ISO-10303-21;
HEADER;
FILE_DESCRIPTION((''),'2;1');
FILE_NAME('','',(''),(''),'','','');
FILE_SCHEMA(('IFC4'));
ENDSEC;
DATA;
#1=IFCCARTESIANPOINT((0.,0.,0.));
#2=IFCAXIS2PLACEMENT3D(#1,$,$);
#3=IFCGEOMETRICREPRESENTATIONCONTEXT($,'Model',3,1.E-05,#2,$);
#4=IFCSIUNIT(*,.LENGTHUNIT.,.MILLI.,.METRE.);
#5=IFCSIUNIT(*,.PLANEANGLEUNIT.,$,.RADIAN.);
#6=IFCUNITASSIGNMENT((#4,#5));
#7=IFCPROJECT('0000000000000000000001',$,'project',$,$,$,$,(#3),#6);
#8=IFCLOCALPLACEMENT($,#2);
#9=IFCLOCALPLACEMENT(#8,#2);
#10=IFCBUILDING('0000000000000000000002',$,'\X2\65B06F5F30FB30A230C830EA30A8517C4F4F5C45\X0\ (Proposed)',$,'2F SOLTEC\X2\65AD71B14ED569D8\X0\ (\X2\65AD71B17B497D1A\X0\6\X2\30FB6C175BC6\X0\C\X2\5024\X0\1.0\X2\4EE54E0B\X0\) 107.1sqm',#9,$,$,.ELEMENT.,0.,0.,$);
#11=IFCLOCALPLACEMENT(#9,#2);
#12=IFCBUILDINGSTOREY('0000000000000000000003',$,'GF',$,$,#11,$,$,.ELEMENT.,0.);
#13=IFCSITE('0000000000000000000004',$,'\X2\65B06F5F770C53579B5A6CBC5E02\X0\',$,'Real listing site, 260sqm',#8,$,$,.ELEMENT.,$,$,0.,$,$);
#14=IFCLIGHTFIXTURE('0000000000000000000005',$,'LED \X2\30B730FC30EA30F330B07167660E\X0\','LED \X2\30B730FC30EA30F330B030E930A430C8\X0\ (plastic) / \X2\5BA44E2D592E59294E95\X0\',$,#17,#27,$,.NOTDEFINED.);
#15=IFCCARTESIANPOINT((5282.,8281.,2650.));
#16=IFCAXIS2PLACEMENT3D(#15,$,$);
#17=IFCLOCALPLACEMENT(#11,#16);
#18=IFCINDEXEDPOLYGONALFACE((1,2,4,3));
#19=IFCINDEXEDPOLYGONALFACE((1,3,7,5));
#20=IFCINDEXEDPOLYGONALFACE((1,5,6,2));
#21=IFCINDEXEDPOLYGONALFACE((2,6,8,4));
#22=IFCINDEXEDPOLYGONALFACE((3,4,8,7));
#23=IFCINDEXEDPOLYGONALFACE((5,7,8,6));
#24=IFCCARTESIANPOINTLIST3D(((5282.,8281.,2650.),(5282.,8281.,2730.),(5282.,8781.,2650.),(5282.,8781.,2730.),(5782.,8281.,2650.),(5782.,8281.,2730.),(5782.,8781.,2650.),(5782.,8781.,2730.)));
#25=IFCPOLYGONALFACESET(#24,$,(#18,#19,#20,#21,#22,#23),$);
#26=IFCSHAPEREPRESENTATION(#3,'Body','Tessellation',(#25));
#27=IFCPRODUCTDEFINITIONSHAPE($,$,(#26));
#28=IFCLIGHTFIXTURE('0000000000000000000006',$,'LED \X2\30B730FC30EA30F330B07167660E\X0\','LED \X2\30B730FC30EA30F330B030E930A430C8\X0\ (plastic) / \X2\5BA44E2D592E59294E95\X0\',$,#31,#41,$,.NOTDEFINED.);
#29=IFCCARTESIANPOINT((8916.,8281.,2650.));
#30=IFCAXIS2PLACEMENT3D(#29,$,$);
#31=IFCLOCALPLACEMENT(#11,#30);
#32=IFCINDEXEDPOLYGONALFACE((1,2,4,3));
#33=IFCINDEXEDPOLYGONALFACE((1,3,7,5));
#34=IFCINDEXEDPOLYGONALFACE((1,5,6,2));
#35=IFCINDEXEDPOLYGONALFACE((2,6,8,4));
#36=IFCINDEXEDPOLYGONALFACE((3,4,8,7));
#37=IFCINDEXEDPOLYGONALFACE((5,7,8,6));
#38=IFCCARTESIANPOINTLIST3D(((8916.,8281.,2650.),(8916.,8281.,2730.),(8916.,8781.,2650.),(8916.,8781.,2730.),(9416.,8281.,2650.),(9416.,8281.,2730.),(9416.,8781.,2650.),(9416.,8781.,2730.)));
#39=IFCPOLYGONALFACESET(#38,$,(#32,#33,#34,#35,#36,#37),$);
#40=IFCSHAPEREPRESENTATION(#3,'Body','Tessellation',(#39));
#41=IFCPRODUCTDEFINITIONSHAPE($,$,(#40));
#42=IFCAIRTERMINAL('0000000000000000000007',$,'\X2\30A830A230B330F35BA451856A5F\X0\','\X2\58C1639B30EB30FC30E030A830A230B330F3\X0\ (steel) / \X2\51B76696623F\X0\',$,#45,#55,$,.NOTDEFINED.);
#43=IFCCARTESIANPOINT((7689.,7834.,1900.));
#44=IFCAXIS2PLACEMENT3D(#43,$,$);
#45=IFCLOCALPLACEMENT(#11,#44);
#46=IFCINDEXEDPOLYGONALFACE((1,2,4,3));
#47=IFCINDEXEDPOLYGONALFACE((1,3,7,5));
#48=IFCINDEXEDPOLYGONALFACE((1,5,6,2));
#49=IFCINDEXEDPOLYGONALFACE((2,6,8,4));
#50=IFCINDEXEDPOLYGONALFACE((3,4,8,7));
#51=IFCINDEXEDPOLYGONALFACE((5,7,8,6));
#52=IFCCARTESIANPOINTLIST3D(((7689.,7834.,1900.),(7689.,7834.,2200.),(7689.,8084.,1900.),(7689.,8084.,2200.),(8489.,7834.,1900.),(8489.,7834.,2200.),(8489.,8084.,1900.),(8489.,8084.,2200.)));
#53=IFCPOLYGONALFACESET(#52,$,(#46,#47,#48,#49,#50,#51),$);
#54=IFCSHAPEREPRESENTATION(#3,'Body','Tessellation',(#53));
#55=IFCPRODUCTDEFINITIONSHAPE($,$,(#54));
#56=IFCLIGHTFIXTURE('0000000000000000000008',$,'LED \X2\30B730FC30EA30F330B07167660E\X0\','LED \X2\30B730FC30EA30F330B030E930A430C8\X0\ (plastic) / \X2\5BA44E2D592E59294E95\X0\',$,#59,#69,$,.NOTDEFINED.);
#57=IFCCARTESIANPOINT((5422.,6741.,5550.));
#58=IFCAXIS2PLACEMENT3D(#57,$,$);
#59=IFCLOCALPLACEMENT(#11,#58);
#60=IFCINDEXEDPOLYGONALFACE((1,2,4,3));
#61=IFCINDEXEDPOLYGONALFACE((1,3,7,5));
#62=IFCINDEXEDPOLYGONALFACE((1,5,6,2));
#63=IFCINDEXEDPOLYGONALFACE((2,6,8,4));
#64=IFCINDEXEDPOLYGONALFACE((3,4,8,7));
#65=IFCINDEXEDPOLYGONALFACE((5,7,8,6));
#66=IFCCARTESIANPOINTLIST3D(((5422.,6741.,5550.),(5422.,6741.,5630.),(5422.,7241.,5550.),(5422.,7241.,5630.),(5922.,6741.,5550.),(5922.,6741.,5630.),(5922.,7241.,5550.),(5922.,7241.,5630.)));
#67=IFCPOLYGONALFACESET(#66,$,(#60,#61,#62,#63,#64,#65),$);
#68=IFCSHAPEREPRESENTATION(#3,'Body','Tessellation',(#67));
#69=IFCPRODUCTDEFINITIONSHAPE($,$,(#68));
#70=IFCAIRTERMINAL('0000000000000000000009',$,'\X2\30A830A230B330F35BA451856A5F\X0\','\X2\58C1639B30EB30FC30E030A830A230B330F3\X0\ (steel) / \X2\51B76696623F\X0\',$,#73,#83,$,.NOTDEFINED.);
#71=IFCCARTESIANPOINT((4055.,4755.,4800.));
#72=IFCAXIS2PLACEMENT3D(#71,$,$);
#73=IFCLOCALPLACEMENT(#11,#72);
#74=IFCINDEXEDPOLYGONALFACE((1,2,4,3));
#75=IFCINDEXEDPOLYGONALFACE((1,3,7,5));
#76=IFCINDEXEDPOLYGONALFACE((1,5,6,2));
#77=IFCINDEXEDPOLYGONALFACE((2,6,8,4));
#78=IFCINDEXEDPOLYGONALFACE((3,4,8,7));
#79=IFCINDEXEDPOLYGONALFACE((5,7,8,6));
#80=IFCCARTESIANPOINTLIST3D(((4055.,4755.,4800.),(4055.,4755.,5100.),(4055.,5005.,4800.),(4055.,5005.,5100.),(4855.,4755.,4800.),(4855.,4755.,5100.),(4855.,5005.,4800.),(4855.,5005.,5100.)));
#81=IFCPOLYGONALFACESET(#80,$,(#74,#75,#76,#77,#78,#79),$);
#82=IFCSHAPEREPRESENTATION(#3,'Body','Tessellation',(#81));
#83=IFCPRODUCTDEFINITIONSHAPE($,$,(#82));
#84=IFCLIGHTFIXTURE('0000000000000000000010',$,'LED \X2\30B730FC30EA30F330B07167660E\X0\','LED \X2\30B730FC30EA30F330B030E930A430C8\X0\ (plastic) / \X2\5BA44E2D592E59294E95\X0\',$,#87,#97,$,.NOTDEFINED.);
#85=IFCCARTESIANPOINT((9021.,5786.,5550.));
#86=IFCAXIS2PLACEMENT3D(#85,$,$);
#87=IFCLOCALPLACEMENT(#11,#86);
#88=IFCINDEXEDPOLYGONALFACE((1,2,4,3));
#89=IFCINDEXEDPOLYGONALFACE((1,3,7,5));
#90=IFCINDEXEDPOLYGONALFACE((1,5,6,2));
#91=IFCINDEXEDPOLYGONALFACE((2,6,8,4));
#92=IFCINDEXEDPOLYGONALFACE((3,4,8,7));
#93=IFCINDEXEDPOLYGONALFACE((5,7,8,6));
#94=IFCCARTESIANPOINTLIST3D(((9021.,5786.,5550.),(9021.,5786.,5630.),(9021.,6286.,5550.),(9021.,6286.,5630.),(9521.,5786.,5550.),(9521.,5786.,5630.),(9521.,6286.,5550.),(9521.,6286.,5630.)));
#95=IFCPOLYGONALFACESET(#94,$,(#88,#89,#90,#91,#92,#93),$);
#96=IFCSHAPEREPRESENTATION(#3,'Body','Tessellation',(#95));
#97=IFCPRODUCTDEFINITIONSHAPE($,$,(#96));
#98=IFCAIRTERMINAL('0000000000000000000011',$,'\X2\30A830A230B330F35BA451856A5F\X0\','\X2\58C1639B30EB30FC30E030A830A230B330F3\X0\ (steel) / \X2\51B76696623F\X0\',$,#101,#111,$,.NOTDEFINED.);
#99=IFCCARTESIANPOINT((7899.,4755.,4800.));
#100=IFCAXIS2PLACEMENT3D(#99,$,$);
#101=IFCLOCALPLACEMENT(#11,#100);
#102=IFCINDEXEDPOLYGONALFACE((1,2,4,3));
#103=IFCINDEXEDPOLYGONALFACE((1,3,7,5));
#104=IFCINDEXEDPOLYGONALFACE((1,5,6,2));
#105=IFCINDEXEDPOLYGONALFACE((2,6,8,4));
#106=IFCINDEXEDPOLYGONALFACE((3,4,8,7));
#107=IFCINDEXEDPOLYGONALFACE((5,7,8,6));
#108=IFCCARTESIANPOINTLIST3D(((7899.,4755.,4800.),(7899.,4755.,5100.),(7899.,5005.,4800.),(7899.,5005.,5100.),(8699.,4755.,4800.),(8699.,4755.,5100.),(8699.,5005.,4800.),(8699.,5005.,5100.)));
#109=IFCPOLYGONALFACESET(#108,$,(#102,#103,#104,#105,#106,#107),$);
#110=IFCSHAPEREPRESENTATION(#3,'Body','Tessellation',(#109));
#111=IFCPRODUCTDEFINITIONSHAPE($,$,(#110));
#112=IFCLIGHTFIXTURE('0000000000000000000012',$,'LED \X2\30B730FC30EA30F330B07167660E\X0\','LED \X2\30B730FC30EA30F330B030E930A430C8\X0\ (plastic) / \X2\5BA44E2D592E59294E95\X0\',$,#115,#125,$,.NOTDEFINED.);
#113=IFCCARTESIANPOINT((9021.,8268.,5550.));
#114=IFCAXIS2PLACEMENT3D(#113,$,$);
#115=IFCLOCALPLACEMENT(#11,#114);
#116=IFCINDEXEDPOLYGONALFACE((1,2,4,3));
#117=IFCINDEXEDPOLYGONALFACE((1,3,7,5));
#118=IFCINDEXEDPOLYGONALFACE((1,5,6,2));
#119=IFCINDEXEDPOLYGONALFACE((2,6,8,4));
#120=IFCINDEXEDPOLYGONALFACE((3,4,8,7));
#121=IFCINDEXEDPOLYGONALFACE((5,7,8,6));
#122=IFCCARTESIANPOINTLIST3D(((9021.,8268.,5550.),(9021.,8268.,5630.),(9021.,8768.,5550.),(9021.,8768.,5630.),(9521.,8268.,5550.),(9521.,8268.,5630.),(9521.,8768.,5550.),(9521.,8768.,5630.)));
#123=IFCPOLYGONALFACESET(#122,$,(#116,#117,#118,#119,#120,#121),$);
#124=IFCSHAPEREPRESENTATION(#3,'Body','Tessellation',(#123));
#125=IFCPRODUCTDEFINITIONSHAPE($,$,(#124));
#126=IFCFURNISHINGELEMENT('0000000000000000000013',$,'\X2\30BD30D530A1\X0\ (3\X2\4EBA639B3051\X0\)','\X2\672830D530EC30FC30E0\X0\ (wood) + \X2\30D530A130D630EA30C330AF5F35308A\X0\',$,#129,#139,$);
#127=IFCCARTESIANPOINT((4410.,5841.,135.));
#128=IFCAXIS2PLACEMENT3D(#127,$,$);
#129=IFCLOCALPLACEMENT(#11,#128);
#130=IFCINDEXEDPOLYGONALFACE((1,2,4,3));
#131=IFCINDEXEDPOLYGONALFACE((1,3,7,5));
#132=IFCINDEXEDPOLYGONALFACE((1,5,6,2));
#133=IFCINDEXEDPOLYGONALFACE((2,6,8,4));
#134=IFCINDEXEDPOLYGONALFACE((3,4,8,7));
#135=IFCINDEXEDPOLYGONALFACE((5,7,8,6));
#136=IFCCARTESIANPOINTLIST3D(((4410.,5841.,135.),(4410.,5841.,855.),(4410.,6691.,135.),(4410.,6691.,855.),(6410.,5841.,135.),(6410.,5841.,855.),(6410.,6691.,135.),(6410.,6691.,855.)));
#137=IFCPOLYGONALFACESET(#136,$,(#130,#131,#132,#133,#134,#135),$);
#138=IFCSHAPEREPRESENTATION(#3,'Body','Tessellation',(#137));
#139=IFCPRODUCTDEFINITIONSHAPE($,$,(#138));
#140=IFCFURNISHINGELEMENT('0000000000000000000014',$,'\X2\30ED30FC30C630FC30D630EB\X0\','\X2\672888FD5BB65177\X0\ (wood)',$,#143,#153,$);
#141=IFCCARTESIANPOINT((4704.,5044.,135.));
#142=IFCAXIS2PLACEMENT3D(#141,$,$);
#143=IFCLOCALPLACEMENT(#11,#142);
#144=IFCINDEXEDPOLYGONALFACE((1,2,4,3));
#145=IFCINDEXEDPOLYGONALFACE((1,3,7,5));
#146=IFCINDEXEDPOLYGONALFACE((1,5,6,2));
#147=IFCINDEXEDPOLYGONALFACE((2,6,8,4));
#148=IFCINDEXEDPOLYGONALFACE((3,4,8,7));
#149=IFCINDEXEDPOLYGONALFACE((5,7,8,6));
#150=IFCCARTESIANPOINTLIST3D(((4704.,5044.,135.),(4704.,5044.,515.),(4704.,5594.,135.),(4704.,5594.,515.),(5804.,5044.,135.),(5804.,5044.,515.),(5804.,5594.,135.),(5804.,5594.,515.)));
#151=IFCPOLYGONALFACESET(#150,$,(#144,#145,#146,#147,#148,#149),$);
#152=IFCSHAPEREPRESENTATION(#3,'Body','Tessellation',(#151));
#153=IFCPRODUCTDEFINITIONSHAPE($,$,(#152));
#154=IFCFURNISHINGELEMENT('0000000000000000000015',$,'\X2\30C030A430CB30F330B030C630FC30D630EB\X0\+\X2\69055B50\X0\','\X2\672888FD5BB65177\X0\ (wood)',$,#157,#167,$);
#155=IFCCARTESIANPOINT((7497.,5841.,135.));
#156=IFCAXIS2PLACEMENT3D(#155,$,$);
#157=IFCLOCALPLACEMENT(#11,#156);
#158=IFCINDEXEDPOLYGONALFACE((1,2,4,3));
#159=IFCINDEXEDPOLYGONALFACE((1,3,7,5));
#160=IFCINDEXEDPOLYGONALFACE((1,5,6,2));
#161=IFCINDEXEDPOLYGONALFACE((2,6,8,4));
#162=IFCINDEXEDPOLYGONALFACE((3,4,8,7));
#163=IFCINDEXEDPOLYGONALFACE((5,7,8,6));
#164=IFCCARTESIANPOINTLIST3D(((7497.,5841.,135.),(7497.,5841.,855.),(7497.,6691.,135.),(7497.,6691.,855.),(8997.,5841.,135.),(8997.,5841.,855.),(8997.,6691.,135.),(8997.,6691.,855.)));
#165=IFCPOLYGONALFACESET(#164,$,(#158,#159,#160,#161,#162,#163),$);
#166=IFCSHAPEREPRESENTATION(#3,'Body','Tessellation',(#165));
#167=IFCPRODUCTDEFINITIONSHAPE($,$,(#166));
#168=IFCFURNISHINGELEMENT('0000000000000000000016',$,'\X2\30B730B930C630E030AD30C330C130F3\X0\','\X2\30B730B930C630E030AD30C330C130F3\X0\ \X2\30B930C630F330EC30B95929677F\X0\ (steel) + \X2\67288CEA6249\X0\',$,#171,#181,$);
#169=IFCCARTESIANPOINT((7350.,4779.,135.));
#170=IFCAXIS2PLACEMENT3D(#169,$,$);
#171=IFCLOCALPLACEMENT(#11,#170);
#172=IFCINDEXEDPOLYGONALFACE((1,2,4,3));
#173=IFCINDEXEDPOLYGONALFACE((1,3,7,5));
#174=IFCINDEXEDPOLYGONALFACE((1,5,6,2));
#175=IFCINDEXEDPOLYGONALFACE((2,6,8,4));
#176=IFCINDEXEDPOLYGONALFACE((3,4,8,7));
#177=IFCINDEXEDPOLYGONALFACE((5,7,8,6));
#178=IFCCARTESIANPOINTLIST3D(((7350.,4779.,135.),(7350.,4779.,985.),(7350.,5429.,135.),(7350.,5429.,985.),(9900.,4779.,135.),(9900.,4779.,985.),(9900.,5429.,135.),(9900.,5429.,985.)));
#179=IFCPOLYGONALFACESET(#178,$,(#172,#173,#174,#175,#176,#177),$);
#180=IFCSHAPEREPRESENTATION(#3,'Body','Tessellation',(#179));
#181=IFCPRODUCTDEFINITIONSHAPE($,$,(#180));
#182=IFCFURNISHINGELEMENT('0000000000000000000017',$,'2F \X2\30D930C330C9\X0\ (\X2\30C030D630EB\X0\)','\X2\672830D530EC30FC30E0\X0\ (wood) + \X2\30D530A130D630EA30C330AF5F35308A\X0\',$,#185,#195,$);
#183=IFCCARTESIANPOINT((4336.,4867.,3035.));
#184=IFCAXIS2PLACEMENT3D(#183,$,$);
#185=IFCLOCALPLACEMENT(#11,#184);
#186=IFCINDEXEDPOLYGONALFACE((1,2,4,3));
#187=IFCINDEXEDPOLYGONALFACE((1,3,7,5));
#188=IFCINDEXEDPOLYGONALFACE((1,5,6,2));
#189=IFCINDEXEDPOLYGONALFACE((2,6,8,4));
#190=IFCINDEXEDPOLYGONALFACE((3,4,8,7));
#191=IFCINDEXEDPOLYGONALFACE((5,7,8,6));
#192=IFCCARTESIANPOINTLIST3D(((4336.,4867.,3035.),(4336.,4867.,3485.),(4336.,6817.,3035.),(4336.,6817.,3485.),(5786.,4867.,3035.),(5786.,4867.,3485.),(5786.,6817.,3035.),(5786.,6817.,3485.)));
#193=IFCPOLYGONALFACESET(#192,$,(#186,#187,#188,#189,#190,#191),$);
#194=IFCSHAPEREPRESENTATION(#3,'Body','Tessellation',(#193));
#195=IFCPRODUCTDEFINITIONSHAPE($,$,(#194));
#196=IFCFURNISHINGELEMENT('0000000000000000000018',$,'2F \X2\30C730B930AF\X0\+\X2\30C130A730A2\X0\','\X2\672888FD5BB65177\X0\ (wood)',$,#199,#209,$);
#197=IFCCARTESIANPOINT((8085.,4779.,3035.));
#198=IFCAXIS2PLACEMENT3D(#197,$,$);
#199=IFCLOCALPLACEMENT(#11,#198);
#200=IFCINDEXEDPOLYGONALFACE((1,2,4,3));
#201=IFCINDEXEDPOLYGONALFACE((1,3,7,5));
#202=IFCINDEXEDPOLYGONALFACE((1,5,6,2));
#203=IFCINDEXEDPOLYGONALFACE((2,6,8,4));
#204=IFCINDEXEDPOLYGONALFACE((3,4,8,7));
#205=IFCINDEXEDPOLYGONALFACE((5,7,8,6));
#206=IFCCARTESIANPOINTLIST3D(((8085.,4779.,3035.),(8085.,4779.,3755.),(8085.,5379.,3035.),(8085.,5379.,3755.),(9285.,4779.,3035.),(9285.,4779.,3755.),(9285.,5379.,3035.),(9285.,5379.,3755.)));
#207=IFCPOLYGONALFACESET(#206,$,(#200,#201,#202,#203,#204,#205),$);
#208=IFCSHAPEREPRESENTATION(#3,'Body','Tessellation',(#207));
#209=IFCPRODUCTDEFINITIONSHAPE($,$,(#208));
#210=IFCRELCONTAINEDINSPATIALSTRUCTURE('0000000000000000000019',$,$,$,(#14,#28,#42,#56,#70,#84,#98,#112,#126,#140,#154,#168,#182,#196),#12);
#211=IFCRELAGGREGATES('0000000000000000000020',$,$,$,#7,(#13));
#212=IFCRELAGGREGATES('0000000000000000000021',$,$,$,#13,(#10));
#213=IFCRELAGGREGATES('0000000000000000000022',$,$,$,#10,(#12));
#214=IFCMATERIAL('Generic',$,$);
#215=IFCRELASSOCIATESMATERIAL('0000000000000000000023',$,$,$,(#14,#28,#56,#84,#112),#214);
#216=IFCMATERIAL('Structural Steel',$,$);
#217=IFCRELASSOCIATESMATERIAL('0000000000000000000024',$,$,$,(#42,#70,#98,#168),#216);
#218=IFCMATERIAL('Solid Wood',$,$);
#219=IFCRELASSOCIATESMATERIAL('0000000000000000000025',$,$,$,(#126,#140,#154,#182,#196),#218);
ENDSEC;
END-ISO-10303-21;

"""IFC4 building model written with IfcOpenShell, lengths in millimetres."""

from ifc_helpers import new_model, si_unit, frame, frame_2d, origin, place, context, project, spatial, rectangle, extrude, material, element, save


model = new_model("IFC4")

# Units and contexts
model_context = context("Model", 3, precision=1e-05, world=origin())
ifc_project = project(units=[si_unit("LENGTHUNIT", "METRE", prefix="MILLI"), si_unit("PLANEANGLEUNIT", "RADIAN")], contexts=[model_context])

# Site, building, storey
site_placement = place(None, origin())
site = spatial("IfcSite", under=ifc_project, at=site_placement, Name="新潟県南魚沼市", ObjectType="Real listing site, 260sqm", CompositionType="ELEMENT", RefElevation=0.0)
building_placement = place(site_placement, origin())
building = spatial("IfcBuilding", under=site, at=building_placement, Name="新潟・アトリエ兼住居 (Proposed)", ObjectType="2F SOLTEC断熱仕様 (断熱等級6・気密C値1.0以下) 107.1sqm", CompositionType="ELEMENT", ElevationOfRefHeight=0.0, ElevationOfTerrain=0.0)
storey_placement = place(building_placement, origin())
storey = spatial("IfcBuildingStorey", under=building, at=storey_placement, Name="GF", CompositionType="ELEMENT", Elevation=0.0)

# Shared definitions
ifc_material_1 = material(Name="Solid Wood")

# Shared definitions
ifc_material_2 = material(Name="Structural Steel")

# Shared definitions
ifc_material_3 = material(Name="Generic")

# Light fixtures
light_fixture_1_placement = place(storey_placement, frame((5282.0, 8281.0, 2650.0)))
element("IfcLightFixture", 1, at=light_fixture_1_placement, inside=storey, material=ifc_material_3, Name="LED シーリング照明", Description="LED シーリングライト (plastic) / 室中央天井", PredefinedType="NOTDEFINED", context=model_context, shape_type="SweptSolid", body=[
    extrude(rectangle(XDim=500.0, YDim=500.0, at=frame_2d((250.0, 250.0))), frame((5282.0, 8281.0, 2650.0)), (0.0, 0.0, 1.0), 80.0),
])
light_fixture_2_placement = place(storey_placement, frame((8916.0, 8281.0, 2650.0)))
element("IfcLightFixture", 2, at=light_fixture_2_placement, inside=storey, material=ifc_material_3, Name="LED シーリング照明", Description="LED シーリングライト (plastic) / 室中央天井", PredefinedType="NOTDEFINED", context=model_context, shape_type="SweptSolid", body=[
    extrude(rectangle(XDim=500.0, YDim=500.0, at=frame_2d((250.0, 250.0))), frame((8916.0, 8281.0, 2650.0)), (0.0, 0.0, 1.0), 80.0),
])

# Air terminal
air_terminal_1_placement = place(storey_placement, frame((7689.0, 7834.0, 1900.0)))
element("IfcAirTerminal", 3, at=air_terminal_1_placement, inside=storey, material=ifc_material_2, Name="エアコン室内機", Description="壁掛ルームエアコン (steel) / 冷暖房", PredefinedType="NOTDEFINED", context=model_context, shape_type="SweptSolid", body=[
    extrude(rectangle(XDim=800.0, YDim=250.0, at=frame_2d((400.0, 125.0))), frame((7689.0, 7834.0, 1900.0)), (0.0, 0.0, 1.0), 300.0),
])

# Light fixture
light_fixture_3_placement = place(storey_placement, frame((5422.0, 6741.0, 5550.0)))
element("IfcLightFixture", 4, at=light_fixture_3_placement, inside=storey, material=ifc_material_3, Name="LED シーリング照明", Description="LED シーリングライト (plastic) / 室中央天井", PredefinedType="NOTDEFINED", context=model_context, shape_type="SweptSolid", body=[
    extrude(rectangle(XDim=500.0, YDim=500.0, at=frame_2d((250.0, 250.0))), frame((5422.0, 6741.0, 5550.0)), (0.0, 0.0, 1.0), 80.0),
])

# Air terminal
air_terminal_2_placement = place(storey_placement, frame((4055.0, 4755.0, 4800.0)))
element("IfcAirTerminal", 5, at=air_terminal_2_placement, inside=storey, material=ifc_material_2, Name="エアコン室内機", Description="壁掛ルームエアコン (steel) / 冷暖房", PredefinedType="NOTDEFINED", context=model_context, shape_type="SweptSolid", body=[
    extrude(rectangle(XDim=800.0, YDim=250.0, at=frame_2d((400.0, 125.0))), frame((4055.0, 4755.0, 4800.0)), (0.0, 0.0, 1.0), 300.0),
])

# Light fixture
light_fixture_4_placement = place(storey_placement, frame((9021.0, 5786.0, 5550.0)))
element("IfcLightFixture", 6, at=light_fixture_4_placement, inside=storey, material=ifc_material_3, Name="LED シーリング照明", Description="LED シーリングライト (plastic) / 室中央天井", PredefinedType="NOTDEFINED", context=model_context, shape_type="SweptSolid", body=[
    extrude(rectangle(XDim=500.0, YDim=500.0, at=frame_2d((250.0, 250.0))), frame((9021.0, 5786.0, 5550.0)), (0.0, 0.0, 1.0), 80.0),
])

# Air terminal
air_terminal_3_placement = place(storey_placement, frame((7899.0, 4755.0, 4800.0)))
element("IfcAirTerminal", 7, at=air_terminal_3_placement, inside=storey, material=ifc_material_2, Name="エアコン室内機", Description="壁掛ルームエアコン (steel) / 冷暖房", PredefinedType="NOTDEFINED", context=model_context, shape_type="SweptSolid", body=[
    extrude(rectangle(XDim=800.0, YDim=250.0, at=frame_2d((400.0, 125.0))), frame((7899.0, 4755.0, 4800.0)), (0.0, 0.0, 1.0), 300.0),
])

# Light fixture
light_fixture_5_placement = place(storey_placement, frame((9021.0, 8268.0, 5550.0)))
element("IfcLightFixture", 8, at=light_fixture_5_placement, inside=storey, material=ifc_material_3, Name="LED シーリング照明", Description="LED シーリングライト (plastic) / 室中央天井", PredefinedType="NOTDEFINED", context=model_context, shape_type="SweptSolid", body=[
    extrude(rectangle(XDim=500.0, YDim=500.0, at=frame_2d((250.0, 250.0))), frame((9021.0, 8268.0, 5550.0)), (0.0, 0.0, 1.0), 80.0),
])

# Furnishing elements
furnishing_1_placement = place(storey_placement, frame((4410.0, 5841.0, 135.0)))
element("IfcFurnishingElement", 9, at=furnishing_1_placement, inside=storey, material=ifc_material_1, Name="ソファ (3人掛け)", Description="木フレーム (wood) + ファブリック張り", context=model_context, shape_type="SweptSolid", body=[
    extrude(rectangle(XDim=2000.0, YDim=850.0, at=frame_2d((1000.0, 425.0))), frame((4410.0, 5841.0, 135.0)), (0.0, 0.0, 1.0), 720.0),
])
furnishing_2_placement = place(storey_placement, frame((4704.0, 5044.0, 135.0)))
element("IfcFurnishingElement", 10, at=furnishing_2_placement, inside=storey, material=ifc_material_1, Name="ローテーブル", Description="木製家具 (wood)", context=model_context, shape_type="SweptSolid", body=[
    extrude(rectangle(XDim=1100.0, YDim=550.0, at=frame_2d((550.0, 275.0))), frame((4704.0, 5044.0, 135.0)), (0.0, 0.0, 1.0), 380.0),
])
furnishing_3_placement = place(storey_placement, frame((7497.0, 5841.0, 135.0)))
element("IfcFurnishingElement", 11, at=furnishing_3_placement, inside=storey, material=ifc_material_1, Name="ダイニングテーブル+椅子", Description="木製家具 (wood)", context=model_context, shape_type="SweptSolid", body=[
    extrude(rectangle(XDim=1500.0, YDim=850.0, at=frame_2d((750.0, 425.0))), frame((7497.0, 5841.0, 135.0)), (0.0, 0.0, 1.0), 720.0),
])
furnishing_4_placement = place(storey_placement, frame((7350.0, 4779.0, 135.0)))
element("IfcFurnishingElement", 12, at=furnishing_4_placement, inside=storey, material=ifc_material_2, Name="システムキッチン", Description="システムキッチン ステンレス天板 (steel) + 木質扉", context=model_context, shape_type="SweptSolid", body=[
    extrude(rectangle(XDim=2550.0, YDim=650.0, at=frame_2d((1275.0, 325.0))), frame((7350.0, 4779.0, 135.0)), (0.0, 0.0, 1.0), 850.0),
])
furnishing_5_placement = place(storey_placement, frame((4336.0, 4867.0, 3035.0)))
element("IfcFurnishingElement", 13, at=furnishing_5_placement, inside=storey, material=ifc_material_1, Name="2F ベッド (ダブル)", Description="木フレーム (wood) + ファブリック張り", context=model_context, shape_type="SweptSolid", body=[
    extrude(rectangle(XDim=1450.0, YDim=1950.0, at=frame_2d((725.0, 975.0))), frame((4336.0, 4867.0, 3035.0)), (0.0, 0.0, 1.0), 450.0),
])
furnishing_6_placement = place(storey_placement, frame((8085.0, 4779.0, 3035.0)))
element("IfcFurnishingElement", 14, at=furnishing_6_placement, inside=storey, material=ifc_material_1, Name="2F デスク+チェア", Description="木製家具 (wood)", context=model_context, shape_type="SweptSolid", body=[
    extrude(rectangle(XDim=1200.0, YDim=600.0, at=frame_2d((600.0, 300.0))), frame((8085.0, 4779.0, 3035.0)), (0.0, 0.0, 1.0), 720.0),
])

save(model, "model.ifc")
